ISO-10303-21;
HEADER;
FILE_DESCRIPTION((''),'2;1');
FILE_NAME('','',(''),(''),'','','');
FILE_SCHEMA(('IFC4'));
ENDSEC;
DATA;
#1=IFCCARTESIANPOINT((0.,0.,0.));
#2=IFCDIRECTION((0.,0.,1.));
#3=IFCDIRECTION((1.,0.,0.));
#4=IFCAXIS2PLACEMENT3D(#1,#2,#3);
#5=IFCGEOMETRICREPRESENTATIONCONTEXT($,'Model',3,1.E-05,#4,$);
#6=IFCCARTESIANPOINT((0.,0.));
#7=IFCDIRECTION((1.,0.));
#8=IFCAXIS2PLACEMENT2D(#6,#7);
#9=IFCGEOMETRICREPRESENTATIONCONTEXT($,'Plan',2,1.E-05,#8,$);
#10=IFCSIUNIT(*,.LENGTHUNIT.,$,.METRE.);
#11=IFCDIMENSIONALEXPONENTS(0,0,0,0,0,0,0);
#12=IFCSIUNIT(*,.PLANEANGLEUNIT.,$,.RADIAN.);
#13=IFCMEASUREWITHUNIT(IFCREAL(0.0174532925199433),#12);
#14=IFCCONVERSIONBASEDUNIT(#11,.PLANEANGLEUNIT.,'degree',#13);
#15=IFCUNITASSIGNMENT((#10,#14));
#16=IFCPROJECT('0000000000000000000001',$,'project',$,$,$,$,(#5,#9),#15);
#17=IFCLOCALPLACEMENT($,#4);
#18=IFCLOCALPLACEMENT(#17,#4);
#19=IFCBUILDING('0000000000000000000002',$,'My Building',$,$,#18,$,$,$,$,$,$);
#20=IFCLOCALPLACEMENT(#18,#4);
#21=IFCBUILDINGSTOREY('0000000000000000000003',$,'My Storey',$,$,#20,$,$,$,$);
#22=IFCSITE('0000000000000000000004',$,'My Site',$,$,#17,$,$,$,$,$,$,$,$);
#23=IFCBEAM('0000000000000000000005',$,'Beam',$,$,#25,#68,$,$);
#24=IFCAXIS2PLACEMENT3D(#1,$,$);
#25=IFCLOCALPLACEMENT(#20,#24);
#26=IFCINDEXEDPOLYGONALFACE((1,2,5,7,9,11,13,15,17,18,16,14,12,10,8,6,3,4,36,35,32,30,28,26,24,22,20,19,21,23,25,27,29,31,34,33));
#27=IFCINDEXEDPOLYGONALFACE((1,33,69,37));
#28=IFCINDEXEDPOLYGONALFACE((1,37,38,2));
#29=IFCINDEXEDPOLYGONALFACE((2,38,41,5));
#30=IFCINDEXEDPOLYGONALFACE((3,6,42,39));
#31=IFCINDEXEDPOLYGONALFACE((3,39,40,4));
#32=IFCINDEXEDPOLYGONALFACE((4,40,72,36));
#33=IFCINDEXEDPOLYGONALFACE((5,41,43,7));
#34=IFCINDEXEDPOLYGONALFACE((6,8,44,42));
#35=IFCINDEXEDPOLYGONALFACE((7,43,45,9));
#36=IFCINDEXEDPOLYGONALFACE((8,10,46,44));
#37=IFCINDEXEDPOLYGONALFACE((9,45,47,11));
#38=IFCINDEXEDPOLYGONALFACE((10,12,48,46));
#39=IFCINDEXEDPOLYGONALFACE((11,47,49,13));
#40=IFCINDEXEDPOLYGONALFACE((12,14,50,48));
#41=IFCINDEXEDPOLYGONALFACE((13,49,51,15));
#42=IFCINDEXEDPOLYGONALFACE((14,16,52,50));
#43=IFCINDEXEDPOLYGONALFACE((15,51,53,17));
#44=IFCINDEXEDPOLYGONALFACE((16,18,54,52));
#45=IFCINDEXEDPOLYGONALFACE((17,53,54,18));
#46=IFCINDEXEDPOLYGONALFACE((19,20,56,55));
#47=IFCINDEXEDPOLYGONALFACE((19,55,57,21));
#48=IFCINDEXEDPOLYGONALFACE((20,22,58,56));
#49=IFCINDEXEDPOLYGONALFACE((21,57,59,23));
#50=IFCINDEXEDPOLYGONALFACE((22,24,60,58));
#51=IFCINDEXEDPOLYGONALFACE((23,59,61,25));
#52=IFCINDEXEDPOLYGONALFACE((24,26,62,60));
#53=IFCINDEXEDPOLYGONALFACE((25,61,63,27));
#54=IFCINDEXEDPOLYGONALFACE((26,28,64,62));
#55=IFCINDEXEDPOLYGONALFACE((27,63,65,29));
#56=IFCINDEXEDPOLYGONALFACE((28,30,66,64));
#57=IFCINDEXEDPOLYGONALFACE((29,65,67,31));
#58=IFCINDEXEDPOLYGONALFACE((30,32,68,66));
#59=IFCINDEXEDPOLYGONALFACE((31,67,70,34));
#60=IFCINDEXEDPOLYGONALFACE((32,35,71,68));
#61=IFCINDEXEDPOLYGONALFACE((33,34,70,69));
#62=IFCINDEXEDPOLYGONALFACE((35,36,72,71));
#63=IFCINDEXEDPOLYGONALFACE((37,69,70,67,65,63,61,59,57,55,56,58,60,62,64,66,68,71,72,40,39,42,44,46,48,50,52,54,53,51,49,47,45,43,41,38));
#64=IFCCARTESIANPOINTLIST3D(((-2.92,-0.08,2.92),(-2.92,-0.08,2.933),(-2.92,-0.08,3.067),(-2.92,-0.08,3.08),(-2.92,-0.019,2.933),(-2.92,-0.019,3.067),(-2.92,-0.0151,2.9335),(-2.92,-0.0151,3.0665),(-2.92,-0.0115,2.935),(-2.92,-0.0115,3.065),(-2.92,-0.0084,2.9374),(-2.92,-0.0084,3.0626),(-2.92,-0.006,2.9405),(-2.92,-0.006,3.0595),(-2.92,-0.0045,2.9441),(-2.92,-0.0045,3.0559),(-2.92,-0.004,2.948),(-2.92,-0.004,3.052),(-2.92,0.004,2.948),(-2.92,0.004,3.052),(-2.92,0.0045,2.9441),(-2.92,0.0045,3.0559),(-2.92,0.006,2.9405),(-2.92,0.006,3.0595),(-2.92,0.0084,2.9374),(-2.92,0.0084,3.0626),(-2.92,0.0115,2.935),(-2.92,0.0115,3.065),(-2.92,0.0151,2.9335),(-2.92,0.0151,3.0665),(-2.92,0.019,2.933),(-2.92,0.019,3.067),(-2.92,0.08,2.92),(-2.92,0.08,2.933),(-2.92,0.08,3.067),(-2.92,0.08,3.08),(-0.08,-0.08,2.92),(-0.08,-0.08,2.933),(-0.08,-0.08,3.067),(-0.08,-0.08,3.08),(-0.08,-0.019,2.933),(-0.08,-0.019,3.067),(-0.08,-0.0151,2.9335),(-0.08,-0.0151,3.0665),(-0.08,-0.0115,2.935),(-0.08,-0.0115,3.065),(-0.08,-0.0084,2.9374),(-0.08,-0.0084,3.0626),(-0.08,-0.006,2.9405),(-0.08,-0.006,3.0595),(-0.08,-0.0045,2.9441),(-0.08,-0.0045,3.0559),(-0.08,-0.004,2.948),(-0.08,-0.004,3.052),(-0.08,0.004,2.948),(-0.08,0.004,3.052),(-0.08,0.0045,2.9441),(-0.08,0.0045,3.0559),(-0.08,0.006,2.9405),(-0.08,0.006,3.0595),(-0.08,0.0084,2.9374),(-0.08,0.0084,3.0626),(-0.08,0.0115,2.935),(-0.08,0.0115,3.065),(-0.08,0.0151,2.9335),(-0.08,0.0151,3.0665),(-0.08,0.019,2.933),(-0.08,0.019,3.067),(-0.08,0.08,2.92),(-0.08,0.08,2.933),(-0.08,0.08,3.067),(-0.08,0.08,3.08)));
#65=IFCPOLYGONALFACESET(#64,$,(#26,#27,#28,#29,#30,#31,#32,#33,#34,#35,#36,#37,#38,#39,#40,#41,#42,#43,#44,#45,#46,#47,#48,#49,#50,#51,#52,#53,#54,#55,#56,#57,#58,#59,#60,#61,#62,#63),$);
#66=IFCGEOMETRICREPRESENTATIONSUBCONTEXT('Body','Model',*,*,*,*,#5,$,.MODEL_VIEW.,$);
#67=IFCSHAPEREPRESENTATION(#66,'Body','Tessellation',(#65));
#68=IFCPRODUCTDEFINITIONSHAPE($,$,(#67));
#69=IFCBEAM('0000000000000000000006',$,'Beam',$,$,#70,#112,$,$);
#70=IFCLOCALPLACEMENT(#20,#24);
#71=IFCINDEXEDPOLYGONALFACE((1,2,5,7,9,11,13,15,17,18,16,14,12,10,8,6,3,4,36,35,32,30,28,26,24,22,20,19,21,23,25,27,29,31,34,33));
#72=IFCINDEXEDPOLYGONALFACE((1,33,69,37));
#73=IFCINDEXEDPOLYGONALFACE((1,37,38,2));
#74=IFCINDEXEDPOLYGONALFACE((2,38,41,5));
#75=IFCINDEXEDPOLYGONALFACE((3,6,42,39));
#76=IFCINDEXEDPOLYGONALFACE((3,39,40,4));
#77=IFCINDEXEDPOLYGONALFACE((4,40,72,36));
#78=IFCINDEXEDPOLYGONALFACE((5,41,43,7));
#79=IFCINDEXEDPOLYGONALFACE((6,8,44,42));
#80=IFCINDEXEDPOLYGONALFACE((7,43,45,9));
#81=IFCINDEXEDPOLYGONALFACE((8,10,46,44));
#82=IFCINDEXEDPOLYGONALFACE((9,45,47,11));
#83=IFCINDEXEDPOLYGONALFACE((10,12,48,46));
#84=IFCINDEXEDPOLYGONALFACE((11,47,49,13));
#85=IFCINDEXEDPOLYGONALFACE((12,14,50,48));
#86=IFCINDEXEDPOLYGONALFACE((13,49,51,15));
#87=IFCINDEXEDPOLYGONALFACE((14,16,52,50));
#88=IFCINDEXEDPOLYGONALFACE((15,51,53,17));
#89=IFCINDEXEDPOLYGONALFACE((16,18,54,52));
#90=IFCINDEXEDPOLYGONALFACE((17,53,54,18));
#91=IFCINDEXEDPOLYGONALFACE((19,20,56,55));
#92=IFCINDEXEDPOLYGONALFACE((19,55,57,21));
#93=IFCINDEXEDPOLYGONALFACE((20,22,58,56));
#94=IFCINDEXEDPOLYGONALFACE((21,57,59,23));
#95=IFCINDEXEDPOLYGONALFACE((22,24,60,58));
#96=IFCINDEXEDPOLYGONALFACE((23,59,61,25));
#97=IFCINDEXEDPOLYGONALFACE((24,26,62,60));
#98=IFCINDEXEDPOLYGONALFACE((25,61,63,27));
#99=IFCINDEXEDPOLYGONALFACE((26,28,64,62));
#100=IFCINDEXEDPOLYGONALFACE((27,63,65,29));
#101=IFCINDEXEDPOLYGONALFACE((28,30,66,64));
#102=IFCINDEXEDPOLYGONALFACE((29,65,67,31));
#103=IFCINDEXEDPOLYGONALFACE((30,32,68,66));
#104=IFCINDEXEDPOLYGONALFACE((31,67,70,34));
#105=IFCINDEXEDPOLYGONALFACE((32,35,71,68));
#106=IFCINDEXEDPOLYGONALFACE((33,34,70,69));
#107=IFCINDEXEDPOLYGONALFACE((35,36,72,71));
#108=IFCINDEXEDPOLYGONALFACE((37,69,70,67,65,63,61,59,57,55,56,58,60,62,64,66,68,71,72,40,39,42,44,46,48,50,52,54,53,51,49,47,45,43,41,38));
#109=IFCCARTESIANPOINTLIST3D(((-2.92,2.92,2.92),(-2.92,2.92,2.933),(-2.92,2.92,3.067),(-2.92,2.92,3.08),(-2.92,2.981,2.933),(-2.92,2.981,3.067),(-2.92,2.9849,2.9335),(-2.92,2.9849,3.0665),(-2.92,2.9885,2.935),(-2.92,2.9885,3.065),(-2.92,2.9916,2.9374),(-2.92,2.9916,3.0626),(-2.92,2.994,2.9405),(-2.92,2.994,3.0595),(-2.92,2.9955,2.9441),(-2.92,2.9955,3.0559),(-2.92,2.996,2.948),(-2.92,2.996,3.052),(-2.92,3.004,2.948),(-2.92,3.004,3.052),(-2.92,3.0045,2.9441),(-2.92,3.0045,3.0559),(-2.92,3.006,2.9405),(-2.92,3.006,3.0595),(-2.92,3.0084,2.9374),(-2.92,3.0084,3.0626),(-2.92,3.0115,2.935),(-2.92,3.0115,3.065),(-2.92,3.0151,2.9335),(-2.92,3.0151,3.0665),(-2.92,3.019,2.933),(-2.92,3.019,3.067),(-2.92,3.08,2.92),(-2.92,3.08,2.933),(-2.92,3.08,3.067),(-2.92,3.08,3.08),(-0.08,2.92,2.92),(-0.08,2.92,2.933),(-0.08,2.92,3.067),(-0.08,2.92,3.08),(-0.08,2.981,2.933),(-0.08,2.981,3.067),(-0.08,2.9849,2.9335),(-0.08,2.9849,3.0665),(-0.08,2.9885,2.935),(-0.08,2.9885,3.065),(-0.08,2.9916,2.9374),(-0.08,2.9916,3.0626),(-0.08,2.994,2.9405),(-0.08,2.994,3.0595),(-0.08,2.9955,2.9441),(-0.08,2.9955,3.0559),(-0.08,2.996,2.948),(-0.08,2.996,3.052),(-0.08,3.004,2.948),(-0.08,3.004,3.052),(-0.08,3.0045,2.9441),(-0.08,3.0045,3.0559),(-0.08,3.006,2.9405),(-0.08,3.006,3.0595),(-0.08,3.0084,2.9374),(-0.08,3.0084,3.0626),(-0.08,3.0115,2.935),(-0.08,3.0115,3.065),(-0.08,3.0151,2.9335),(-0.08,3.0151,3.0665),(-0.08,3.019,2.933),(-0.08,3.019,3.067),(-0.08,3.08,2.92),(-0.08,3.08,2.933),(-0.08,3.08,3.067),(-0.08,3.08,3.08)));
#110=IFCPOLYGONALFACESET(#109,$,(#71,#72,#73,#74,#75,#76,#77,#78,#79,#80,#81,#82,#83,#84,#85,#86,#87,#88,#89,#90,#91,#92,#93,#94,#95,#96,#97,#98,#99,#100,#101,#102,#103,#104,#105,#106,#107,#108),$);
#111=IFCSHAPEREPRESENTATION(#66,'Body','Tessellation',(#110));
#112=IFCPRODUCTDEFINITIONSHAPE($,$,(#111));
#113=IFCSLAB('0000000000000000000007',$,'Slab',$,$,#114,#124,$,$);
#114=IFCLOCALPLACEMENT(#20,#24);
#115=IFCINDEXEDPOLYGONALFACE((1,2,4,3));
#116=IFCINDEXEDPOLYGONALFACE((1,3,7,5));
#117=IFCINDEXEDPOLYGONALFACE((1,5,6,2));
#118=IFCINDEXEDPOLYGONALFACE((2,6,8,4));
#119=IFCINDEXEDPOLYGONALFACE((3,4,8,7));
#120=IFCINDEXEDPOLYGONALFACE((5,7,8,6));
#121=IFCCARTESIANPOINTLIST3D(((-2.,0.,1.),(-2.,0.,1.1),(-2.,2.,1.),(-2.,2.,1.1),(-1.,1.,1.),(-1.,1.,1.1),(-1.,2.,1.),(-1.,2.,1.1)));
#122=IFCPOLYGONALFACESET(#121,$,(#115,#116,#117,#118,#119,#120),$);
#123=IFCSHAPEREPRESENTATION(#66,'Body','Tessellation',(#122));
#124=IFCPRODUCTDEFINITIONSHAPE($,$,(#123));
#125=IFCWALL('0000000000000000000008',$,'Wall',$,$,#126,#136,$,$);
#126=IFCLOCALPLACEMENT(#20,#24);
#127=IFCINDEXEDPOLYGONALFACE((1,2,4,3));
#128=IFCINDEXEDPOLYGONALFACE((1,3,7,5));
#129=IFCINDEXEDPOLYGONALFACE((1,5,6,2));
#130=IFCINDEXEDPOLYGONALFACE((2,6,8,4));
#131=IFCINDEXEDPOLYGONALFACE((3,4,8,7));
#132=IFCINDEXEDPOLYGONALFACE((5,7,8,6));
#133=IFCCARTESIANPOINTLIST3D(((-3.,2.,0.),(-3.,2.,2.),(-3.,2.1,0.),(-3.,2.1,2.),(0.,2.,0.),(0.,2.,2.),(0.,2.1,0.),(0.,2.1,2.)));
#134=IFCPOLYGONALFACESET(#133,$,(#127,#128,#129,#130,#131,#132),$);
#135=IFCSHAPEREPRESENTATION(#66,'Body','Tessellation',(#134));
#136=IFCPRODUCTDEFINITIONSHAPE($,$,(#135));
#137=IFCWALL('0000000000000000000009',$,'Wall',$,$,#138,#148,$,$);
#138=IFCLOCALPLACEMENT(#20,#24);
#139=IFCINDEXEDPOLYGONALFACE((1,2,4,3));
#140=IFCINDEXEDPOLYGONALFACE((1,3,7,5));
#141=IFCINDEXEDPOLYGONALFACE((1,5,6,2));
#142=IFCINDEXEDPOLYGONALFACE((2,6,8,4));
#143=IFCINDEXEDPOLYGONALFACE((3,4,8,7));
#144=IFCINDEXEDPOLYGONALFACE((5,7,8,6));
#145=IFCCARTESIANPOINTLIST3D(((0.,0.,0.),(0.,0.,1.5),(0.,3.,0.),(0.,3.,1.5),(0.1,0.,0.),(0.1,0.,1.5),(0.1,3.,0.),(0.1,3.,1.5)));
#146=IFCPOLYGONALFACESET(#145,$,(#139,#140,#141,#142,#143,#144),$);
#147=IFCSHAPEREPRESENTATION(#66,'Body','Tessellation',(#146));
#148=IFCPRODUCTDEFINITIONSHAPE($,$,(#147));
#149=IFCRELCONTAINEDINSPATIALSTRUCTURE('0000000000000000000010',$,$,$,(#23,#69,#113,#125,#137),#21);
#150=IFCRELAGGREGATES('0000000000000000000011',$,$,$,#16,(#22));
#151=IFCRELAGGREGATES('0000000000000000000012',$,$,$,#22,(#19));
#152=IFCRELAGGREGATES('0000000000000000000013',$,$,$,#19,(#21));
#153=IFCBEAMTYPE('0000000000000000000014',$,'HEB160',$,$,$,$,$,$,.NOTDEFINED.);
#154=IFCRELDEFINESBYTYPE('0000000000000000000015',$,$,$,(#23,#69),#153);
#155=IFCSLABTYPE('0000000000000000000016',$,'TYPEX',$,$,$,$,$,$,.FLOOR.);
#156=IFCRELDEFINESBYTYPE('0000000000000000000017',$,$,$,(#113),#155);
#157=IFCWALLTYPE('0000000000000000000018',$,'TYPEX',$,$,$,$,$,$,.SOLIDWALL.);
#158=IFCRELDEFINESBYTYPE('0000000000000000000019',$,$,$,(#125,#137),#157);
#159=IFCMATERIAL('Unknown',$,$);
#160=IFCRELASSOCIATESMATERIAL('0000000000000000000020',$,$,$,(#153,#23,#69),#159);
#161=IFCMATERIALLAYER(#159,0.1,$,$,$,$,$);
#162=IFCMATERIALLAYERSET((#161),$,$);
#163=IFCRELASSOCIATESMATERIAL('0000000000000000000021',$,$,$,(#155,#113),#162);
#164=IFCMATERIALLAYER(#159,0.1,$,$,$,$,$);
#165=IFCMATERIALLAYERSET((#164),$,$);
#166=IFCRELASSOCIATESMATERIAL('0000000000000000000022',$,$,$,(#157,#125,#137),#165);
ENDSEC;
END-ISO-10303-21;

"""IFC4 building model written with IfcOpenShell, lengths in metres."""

from ifc_helpers import new_model, entity, si_unit, converted_unit, frame, origin_with_axes, origin_2d_with_axis, place, context, subcontext, project, spatial, line, indexed_curve, i_section, outline, extrude, material, layer, layer_set, layer_usage, material_profile, profile_set, profile_usage, type_object, element, save


model = new_model("IFC4")

# Units and contexts
model_context = context("Model", 3, precision=1e-05, world=origin_with_axes())
plan_context = context("Plan", 2, precision=1e-05, world=origin_2d_with_axis())
body_context = subcontext(model_context, "Body", "Model", "MODEL_VIEW")
ifc_project = project(units=[si_unit("LENGTHUNIT", "METRE"), converted_unit("PLANEANGLEUNIT", "degree", entity("IfcReal", 0.0174532925199433), si_unit("PLANEANGLEUNIT", "RADIAN"), dimensions=[0, 0, 0, 0, 0, 0, 0])], contexts=[model_context, plan_context])

# Site, building, storey
site_placement = place(None, origin_with_axes())
site = spatial("IfcSite", under=ifc_project, at=site_placement, Name="My Site")
building_placement = place(site_placement, origin_with_axes())
building = spatial("IfcBuilding", under=site, at=building_placement, Name="My Building")
storey_placement = place(building_placement, origin_with_axes())
storey = spatial("IfcBuildingStorey", under=building, at=storey_placement, Name="My Storey")

# Shared definitions
ifc_material = material(Name="Unknown")

# Beams
ifc_material_profile_1 = material_profile(ifc_material, i_section(OverallWidth=0.16, OverallDepth=0.16, WebThickness=0.008, FlangeThickness=0.013, FilletRadius=0.015))
ifc_profile_set_1 = profile_set([ifc_material_profile_1])
beam_type_1 = type_object("IfcBeamType", Name="HEB160", PredefinedType="NOTDEFINED", material=ifc_profile_set_1)
ifc_profile_usage_1 = profile_usage(ifc_profile_set_1, cardinal=5)
beam_1_placement = place(storey_placement, frame((-2.92, 0.0, 3.0), z_axis=(1.0, 0.0, 0.0), x_axis=(0.0, 1.0, 0.0)))
element("IfcBeam", 1, at=beam_1_placement, inside=storey, type_object=beam_type_1, material=ifc_profile_usage_1, Name="Beam", context=body_context, shape_type="SweptSolid", body=[
    extrude(i_section(OverallWidth=0.16, OverallDepth=0.16, WebThickness=0.008, FlangeThickness=0.013, FilletRadius=0.015), origin_with_axes(), (0.0, 0.0, 1.0), 2.84),
])
ifc_profile_usage_2 = profile_usage(ifc_profile_set_1, cardinal=5)
beam_2_placement = place(storey_placement, frame((-2.92, 3.0, 3.0), z_axis=(1.0, 0.0, 0.0), x_axis=(0.0, 1.0, 0.0)))
element("IfcBeam", 2, at=beam_2_placement, inside=storey, type_object=beam_type_1, material=ifc_profile_usage_2, Name="Beam", context=body_context, shape_type="SweptSolid", body=[
    extrude(i_section(OverallWidth=0.16, OverallDepth=0.16, WebThickness=0.008, FlangeThickness=0.013, FilletRadius=0.015), origin_with_axes(), (0.0, 0.0, 1.0), 2.84),
])

# Slab
ifc_layer_1 = layer(ifc_material, 0.1)
ifc_layer_set_1 = layer_set([ifc_layer_1])
slab_type = type_object("IfcSlabType", Name="TYPEX", PredefinedType="FLOOR", material=ifc_layer_set_1)
ifc_layer_usage_1 = layer_usage(ifc_layer_set_1, "AXIS3", "POSITIVE", 0.0)
slab_1_placement = place(storey_placement, frame((-2.0, 1.0, 1.0), z_axis=(0.0, 0.0, 1.0), x_axis=(1.0, 0.0, 0.0)))
element("IfcSlab", 3, at=slab_1_placement, inside=storey, type_object=slab_type, material=ifc_layer_usage_1, Name="Slab", context=body_context, shape_type="SweptSolid", body=[
    extrude(outline(indexed_curve([(0.0, -1.0), (1.0, 0.0), (1.0, 1.0), (0.0, 1.0)], segments=[line(3, 2), line(2, 1), line(1, 4), line(4, 3)], self_intersect=False)), None, (0.0, 0.0, 1.0), 0.1),
])

# Walls
ifc_layer_2 = layer(ifc_material, 0.1)
ifc_layer_set_2 = layer_set([ifc_layer_2])
ifc_layer_usage_2 = layer_usage(ifc_layer_set_2, "AXIS2", "POSITIVE", 0.0)
wall_type = type_object("IfcWallType", Name="TYPEX", PredefinedType="SOLIDWALL", material=ifc_layer_set_2)
wall_1_placement = place(storey_placement, frame((-3.0, 2.0, 0.0), z_axis=(0.0, 0.0, 1.0), x_axis=(1.0, 0.0, 0.0)))
element("IfcWall", 4, at=wall_1_placement, inside=storey, type_object=wall_type, material=ifc_layer_usage_2, Name="Wall", context=body_context, shape_type="SweptSolid", body=[
    extrude(outline(indexed_curve([(0.0, 0.0), (0.0, 0.1), (3.0, 0.1), (3.0, 0.0), (0.0, 0.0)], self_intersect=False)), origin_with_axes(), (0.0, 0.0, 1.0), 2.0),
])
ifc_layer_usage_3 = layer_usage(ifc_layer_set_2, "AXIS2", "POSITIVE", 0.0)
wall_2_placement = place(storey_placement, frame((0.0, 3.0, 0.0), z_axis=(0.0, 0.0, 1.0), x_axis=(-0.000001, -1.0, 0.0)))
element("IfcWall", 5, at=wall_2_placement, inside=storey, type_object=wall_type, material=ifc_layer_usage_3, Name="Wall", context=body_context, shape_type="SweptSolid", body=[
    extrude(outline(indexed_curve([(0.0, 0.0), (0.0, 0.1), (3.0, 0.1), (3.0, 0.0), (0.0, 0.0)], self_intersect=False)), origin_with_axes(), (0.0, 0.0, 1.0), 1.5),
])

save(model, "model.ifc")
